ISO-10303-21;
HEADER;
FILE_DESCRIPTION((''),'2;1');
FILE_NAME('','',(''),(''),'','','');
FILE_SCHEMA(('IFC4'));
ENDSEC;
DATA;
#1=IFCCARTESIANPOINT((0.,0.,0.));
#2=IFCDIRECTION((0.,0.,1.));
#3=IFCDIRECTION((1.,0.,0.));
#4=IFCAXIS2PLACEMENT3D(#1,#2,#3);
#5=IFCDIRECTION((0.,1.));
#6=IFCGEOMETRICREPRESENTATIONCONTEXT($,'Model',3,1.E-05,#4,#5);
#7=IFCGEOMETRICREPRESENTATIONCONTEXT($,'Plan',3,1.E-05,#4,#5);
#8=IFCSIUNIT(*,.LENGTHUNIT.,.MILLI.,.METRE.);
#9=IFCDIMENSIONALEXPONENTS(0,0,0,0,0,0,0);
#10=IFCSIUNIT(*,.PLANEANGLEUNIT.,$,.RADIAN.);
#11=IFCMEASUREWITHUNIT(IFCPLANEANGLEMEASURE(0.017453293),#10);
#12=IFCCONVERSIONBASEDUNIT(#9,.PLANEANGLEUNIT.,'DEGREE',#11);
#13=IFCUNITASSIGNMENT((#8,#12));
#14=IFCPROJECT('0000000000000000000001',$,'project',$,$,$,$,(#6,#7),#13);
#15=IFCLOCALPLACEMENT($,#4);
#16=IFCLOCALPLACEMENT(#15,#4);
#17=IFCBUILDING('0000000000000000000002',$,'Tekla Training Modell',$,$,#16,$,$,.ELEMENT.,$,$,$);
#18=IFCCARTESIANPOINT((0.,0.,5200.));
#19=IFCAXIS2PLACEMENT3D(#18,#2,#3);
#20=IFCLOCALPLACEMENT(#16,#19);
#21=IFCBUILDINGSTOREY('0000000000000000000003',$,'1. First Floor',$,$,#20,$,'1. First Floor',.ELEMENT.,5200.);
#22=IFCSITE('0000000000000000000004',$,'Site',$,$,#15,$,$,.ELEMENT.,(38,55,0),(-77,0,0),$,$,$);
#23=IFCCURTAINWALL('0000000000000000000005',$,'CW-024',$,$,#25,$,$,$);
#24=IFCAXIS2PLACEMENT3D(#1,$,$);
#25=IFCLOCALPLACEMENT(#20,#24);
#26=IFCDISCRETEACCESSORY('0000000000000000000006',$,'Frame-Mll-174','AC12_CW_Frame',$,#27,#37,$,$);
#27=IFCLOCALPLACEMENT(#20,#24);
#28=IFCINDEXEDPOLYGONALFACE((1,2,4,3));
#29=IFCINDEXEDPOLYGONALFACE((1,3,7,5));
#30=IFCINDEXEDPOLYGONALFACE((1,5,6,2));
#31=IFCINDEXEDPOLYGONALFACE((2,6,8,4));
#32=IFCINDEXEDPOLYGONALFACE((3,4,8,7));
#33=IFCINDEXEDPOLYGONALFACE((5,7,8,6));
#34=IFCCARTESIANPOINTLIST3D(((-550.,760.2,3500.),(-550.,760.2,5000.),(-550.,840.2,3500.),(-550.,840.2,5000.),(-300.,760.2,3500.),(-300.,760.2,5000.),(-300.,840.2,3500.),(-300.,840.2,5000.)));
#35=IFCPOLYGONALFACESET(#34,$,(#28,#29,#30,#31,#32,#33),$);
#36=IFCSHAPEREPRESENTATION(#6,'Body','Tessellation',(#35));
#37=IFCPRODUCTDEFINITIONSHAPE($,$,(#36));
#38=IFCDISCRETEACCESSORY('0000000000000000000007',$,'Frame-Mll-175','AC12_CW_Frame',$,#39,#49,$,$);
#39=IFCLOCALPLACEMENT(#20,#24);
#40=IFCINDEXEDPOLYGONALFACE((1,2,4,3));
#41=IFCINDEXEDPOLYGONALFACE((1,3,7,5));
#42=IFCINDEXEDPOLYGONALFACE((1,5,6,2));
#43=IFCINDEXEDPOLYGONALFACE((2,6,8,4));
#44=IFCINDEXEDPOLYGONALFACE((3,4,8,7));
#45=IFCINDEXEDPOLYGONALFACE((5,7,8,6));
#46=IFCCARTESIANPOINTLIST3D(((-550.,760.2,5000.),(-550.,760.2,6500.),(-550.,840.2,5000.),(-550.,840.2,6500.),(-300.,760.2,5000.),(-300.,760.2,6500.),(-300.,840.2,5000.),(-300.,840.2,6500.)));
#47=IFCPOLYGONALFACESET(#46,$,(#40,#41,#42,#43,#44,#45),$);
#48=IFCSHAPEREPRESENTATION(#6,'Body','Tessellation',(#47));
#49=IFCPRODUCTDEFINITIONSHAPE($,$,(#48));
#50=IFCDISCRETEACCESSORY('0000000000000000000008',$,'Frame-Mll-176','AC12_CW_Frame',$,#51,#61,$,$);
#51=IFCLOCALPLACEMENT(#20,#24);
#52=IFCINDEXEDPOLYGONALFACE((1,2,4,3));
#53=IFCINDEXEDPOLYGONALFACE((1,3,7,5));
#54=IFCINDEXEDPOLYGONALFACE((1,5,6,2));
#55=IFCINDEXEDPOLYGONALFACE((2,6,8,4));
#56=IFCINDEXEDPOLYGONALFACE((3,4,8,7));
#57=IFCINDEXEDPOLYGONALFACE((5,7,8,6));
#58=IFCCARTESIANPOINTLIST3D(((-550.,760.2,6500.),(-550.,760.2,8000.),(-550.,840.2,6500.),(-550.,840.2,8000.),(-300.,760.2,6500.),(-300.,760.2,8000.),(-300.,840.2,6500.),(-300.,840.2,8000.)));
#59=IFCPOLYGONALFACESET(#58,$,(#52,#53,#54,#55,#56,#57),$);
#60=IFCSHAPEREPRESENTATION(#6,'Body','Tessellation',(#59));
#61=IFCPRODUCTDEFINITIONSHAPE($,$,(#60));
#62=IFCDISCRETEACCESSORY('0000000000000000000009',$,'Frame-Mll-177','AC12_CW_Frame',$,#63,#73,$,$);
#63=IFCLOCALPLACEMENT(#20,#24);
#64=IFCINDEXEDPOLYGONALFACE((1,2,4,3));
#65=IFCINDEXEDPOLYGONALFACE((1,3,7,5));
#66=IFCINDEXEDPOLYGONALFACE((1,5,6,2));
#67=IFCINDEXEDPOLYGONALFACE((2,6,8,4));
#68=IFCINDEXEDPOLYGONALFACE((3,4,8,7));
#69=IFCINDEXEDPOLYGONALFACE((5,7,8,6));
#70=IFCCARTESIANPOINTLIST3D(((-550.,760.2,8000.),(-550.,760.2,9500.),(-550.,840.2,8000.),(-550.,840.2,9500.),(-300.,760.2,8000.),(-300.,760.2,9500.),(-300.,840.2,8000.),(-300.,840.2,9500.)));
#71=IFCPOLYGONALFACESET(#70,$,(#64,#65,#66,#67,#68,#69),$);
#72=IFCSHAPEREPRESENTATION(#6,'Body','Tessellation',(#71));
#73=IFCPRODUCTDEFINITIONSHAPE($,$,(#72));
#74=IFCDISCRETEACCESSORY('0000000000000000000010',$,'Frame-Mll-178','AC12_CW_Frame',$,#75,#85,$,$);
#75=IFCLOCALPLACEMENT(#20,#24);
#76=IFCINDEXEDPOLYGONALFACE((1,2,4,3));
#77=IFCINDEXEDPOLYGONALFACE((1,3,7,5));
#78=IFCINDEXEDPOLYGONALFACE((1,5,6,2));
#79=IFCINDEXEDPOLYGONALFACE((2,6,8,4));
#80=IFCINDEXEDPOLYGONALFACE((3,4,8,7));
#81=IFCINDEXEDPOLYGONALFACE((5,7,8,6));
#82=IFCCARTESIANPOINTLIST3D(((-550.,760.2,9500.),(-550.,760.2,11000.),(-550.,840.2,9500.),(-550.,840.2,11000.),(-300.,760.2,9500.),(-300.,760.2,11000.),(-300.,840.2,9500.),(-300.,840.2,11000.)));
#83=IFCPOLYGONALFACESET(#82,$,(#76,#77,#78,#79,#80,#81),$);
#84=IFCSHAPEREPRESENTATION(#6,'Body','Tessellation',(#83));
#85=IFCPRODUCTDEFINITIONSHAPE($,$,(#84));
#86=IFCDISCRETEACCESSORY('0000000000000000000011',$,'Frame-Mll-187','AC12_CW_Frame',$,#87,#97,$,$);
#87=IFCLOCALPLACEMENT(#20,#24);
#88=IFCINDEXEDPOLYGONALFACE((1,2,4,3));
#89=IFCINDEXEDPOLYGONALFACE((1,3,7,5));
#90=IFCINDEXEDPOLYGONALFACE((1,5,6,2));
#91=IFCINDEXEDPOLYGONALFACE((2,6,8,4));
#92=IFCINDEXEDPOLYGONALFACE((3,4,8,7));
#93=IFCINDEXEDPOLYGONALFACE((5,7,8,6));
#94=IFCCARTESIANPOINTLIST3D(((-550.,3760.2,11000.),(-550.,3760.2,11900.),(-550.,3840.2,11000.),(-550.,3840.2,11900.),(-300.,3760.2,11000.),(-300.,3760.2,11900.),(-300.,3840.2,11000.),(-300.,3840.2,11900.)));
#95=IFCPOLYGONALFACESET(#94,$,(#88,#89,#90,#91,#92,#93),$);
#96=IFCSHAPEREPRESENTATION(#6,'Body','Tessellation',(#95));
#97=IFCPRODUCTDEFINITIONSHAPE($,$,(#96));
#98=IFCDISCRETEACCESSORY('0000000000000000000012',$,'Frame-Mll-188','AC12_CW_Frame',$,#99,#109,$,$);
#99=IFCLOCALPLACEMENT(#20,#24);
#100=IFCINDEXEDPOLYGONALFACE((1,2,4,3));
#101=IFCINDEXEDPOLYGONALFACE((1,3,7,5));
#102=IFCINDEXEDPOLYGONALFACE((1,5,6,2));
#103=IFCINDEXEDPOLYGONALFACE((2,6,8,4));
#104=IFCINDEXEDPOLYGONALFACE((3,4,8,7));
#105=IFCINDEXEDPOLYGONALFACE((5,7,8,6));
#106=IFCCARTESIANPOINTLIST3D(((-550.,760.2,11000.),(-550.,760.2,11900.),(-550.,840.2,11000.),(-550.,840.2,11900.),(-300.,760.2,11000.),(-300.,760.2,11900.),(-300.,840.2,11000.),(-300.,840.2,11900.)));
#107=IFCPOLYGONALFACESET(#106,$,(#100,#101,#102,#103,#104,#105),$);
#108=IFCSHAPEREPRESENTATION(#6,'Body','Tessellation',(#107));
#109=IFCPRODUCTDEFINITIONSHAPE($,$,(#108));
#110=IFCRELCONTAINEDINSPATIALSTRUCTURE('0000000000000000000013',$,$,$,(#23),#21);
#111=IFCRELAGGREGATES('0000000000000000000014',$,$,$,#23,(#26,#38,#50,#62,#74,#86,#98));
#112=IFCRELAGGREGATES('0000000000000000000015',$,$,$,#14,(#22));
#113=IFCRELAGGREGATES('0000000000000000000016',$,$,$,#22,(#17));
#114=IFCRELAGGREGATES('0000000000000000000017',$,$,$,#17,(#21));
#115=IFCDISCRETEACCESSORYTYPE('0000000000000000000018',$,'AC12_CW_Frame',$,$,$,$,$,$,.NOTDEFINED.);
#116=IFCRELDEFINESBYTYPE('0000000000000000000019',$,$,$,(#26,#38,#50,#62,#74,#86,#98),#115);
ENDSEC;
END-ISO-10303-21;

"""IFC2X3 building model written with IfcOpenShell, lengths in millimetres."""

from ifc_helpers import new_model, entity, si_unit, converted_unit, direction, frame, origin_with_axes, place, context, project, spatial, polyline, outline, extrude, source, transform, mapped, type_object, element, aggregate, save


model = new_model("IFC2X3")

# Units and contexts
model_context = context("Model", 3, precision=1e-05, world=origin_with_axes(), true_north=direction((0.0, 1.0)))
plan_context = context("Plan", 3, precision=1e-05, world=origin_with_axes(), true_north=direction((0.0, 1.0)))
ifc_project = project(units=[si_unit("LENGTHUNIT", "METRE", prefix="MILLI"), converted_unit("PLANEANGLEUNIT", "DEGREE", entity("IfcPlaneAngleMeasure", 0.017453293), si_unit("PLANEANGLEUNIT", "RADIAN"), dimensions=[0, 0, 0, 0, 0, 0, 0])], contexts=[model_context, plan_context])

# Site, building, storey
site_placement = place(None, origin_with_axes())
site = spatial("IfcSite", under=ifc_project, at=site_placement, Name="Site", CompositionType="ELEMENT", RefLatitude=(38, 55, 0), RefLongitude=(-77, 0, 0))
building_placement = place(site_placement, origin_with_axes())
building = spatial("IfcBuilding", under=site, at=building_placement, Name="Tekla Training Modell", CompositionType="ELEMENT")
storey_placement = place(building_placement, frame((0.0, 0.0, 5200.0), z_axis=(0.0, 0.0, 1.0), x_axis=(1.0, 0.0, 0.0)))
storey = spatial("IfcBuildingStorey", under=building, at=storey_placement, Name="1. First Floor", LongName="1. First Floor", CompositionType="ELEMENT", Elevation=5200.0)

# Curtain wall, discrete accessories
curtain_wall_placement = place(storey_placement, frame((-500.0, 6800.2, -1000.0), z_axis=(0.0, 0.0, 1.0), x_axis=(0.0, -1.0, 0.0)))
curtain_wall = element("IfcCurtainWall", 1, at=curtain_wall_placement, inside=storey, Name="CW-024")
discrete_accessory_type = type_object("IfcDiscreteAccessoryType", Name="AC12_CW_Frame")
shared_shape_1 = source(origin_with_axes(), model_context, "Body", "SweptSolid", [
    extrude(outline(polyline([(0.0, 0.0), (250.0, 0.0), (250.0, -1500.0), (0.0, -1500.0), (0.0, 0.0)])), origin_with_axes(), (0.0, 0.0, 1.0), 80.0),
])
discrete_accessory_1_placement = place(storey_placement, frame((-300.0, 840.2, 3500.0), z_axis=(0.0, -1.0, 0.0), x_axis=(-1.0, 0.0, 0.0)))
discrete_accessory_1 = element("IfcDiscreteAccessory", 2, at=discrete_accessory_1_placement, type_object=discrete_accessory_type, Name="Frame-Mll-174", Description="AC12_CW_Frame", context=model_context, shape_type="MappedRepresentation", body=[
    mapped(shared_shape_1, transform((0.0, 0.0, 0.0), scale=1.0)),
])
discrete_accessory_2_placement = place(storey_placement, frame((-300.0, 840.2, 5000.0), z_axis=(0.0, -1.0, 0.0), x_axis=(-1.0, 0.0, 0.0)))
discrete_accessory_2 = element("IfcDiscreteAccessory", 3, at=discrete_accessory_2_placement, type_object=discrete_accessory_type, Name="Frame-Mll-175", Description="AC12_CW_Frame", context=model_context, shape_type="MappedRepresentation", body=[
    mapped(shared_shape_1, transform((0.0, 0.0, 0.0), scale=1.0)),
])
discrete_accessory_3_placement = place(storey_placement, frame((-300.0, 840.2, 6500.0), z_axis=(0.0, -1.0, 0.0), x_axis=(-1.0, 0.0, 0.0)))
discrete_accessory_3 = element("IfcDiscreteAccessory", 4, at=discrete_accessory_3_placement, type_object=discrete_accessory_type, Name="Frame-Mll-176", Description="AC12_CW_Frame", context=model_context, shape_type="MappedRepresentation", body=[
    mapped(shared_shape_1, transform((0.0, 0.0, 0.0), scale=1.0)),
])
discrete_accessory_4_placement = place(storey_placement, frame((-300.0, 840.2, 8000.0), z_axis=(0.0, -1.0, 0.0), x_axis=(-1.0, 0.0, 0.0)))
discrete_accessory_4 = element("IfcDiscreteAccessory", 5, at=discrete_accessory_4_placement, type_object=discrete_accessory_type, Name="Frame-Mll-177", Description="AC12_CW_Frame", context=model_context, shape_type="MappedRepresentation", body=[
    mapped(shared_shape_1, transform((0.0, 0.0, 0.0), scale=1.0)),
])
discrete_accessory_5_placement = place(storey_placement, frame((-300.0, 840.2, 9500.0), z_axis=(0.0, -1.0, 0.0), x_axis=(-1.0, 0.0, 0.0)))
discrete_accessory_5 = element("IfcDiscreteAccessory", 6, at=discrete_accessory_5_placement, type_object=discrete_accessory_type, Name="Frame-Mll-178", Description="AC12_CW_Frame", context=model_context, shape_type="MappedRepresentation", body=[
    mapped(shared_shape_1, transform((0.0, 0.0, 0.0), scale=1.0)),
])
shared_shape_2 = source(origin_with_axes(), model_context, "Body", "SweptSolid", [
    extrude(outline(polyline([(0.0, 0.0), (250.0, 0.0), (250.0, -900.0), (0.0, -900.0), (0.0, 0.0)])), origin_with_axes(), (0.0, 0.0, 1.0), 80.0),
])
discrete_accessory_6_placement = place(storey_placement, frame((-300.0, 3840.2, 11000.0), z_axis=(0.0, -1.0, 0.0), x_axis=(-1.0, 0.0, 0.0)))
discrete_accessory_6 = element("IfcDiscreteAccessory", 7, at=discrete_accessory_6_placement, type_object=discrete_accessory_type, Name="Frame-Mll-187", Description="AC12_CW_Frame", context=model_context, shape_type="MappedRepresentation", body=[
    mapped(shared_shape_2, transform((0.0, 0.0, 0.0), scale=1.0)),
])
discrete_accessory_7_placement = place(storey_placement, frame((-300.0, 840.2, 11000.0), z_axis=(0.0, -1.0, 0.0), x_axis=(-1.0, 0.0, 0.0)))
discrete_accessory_7 = element("IfcDiscreteAccessory", 8, at=discrete_accessory_7_placement, type_object=discrete_accessory_type, Name="Frame-Mll-188", Description="AC12_CW_Frame", context=model_context, shape_type="MappedRepresentation", body=[
    mapped(shared_shape_2, transform((0.0, 0.0, 0.0), scale=1.0)),
])
aggregate(curtain_wall, [discrete_accessory_1, discrete_accessory_2, discrete_accessory_3, discrete_accessory_4, discrete_accessory_5, discrete_accessory_6, discrete_accessory_7])

save(model, "model.ifc")
